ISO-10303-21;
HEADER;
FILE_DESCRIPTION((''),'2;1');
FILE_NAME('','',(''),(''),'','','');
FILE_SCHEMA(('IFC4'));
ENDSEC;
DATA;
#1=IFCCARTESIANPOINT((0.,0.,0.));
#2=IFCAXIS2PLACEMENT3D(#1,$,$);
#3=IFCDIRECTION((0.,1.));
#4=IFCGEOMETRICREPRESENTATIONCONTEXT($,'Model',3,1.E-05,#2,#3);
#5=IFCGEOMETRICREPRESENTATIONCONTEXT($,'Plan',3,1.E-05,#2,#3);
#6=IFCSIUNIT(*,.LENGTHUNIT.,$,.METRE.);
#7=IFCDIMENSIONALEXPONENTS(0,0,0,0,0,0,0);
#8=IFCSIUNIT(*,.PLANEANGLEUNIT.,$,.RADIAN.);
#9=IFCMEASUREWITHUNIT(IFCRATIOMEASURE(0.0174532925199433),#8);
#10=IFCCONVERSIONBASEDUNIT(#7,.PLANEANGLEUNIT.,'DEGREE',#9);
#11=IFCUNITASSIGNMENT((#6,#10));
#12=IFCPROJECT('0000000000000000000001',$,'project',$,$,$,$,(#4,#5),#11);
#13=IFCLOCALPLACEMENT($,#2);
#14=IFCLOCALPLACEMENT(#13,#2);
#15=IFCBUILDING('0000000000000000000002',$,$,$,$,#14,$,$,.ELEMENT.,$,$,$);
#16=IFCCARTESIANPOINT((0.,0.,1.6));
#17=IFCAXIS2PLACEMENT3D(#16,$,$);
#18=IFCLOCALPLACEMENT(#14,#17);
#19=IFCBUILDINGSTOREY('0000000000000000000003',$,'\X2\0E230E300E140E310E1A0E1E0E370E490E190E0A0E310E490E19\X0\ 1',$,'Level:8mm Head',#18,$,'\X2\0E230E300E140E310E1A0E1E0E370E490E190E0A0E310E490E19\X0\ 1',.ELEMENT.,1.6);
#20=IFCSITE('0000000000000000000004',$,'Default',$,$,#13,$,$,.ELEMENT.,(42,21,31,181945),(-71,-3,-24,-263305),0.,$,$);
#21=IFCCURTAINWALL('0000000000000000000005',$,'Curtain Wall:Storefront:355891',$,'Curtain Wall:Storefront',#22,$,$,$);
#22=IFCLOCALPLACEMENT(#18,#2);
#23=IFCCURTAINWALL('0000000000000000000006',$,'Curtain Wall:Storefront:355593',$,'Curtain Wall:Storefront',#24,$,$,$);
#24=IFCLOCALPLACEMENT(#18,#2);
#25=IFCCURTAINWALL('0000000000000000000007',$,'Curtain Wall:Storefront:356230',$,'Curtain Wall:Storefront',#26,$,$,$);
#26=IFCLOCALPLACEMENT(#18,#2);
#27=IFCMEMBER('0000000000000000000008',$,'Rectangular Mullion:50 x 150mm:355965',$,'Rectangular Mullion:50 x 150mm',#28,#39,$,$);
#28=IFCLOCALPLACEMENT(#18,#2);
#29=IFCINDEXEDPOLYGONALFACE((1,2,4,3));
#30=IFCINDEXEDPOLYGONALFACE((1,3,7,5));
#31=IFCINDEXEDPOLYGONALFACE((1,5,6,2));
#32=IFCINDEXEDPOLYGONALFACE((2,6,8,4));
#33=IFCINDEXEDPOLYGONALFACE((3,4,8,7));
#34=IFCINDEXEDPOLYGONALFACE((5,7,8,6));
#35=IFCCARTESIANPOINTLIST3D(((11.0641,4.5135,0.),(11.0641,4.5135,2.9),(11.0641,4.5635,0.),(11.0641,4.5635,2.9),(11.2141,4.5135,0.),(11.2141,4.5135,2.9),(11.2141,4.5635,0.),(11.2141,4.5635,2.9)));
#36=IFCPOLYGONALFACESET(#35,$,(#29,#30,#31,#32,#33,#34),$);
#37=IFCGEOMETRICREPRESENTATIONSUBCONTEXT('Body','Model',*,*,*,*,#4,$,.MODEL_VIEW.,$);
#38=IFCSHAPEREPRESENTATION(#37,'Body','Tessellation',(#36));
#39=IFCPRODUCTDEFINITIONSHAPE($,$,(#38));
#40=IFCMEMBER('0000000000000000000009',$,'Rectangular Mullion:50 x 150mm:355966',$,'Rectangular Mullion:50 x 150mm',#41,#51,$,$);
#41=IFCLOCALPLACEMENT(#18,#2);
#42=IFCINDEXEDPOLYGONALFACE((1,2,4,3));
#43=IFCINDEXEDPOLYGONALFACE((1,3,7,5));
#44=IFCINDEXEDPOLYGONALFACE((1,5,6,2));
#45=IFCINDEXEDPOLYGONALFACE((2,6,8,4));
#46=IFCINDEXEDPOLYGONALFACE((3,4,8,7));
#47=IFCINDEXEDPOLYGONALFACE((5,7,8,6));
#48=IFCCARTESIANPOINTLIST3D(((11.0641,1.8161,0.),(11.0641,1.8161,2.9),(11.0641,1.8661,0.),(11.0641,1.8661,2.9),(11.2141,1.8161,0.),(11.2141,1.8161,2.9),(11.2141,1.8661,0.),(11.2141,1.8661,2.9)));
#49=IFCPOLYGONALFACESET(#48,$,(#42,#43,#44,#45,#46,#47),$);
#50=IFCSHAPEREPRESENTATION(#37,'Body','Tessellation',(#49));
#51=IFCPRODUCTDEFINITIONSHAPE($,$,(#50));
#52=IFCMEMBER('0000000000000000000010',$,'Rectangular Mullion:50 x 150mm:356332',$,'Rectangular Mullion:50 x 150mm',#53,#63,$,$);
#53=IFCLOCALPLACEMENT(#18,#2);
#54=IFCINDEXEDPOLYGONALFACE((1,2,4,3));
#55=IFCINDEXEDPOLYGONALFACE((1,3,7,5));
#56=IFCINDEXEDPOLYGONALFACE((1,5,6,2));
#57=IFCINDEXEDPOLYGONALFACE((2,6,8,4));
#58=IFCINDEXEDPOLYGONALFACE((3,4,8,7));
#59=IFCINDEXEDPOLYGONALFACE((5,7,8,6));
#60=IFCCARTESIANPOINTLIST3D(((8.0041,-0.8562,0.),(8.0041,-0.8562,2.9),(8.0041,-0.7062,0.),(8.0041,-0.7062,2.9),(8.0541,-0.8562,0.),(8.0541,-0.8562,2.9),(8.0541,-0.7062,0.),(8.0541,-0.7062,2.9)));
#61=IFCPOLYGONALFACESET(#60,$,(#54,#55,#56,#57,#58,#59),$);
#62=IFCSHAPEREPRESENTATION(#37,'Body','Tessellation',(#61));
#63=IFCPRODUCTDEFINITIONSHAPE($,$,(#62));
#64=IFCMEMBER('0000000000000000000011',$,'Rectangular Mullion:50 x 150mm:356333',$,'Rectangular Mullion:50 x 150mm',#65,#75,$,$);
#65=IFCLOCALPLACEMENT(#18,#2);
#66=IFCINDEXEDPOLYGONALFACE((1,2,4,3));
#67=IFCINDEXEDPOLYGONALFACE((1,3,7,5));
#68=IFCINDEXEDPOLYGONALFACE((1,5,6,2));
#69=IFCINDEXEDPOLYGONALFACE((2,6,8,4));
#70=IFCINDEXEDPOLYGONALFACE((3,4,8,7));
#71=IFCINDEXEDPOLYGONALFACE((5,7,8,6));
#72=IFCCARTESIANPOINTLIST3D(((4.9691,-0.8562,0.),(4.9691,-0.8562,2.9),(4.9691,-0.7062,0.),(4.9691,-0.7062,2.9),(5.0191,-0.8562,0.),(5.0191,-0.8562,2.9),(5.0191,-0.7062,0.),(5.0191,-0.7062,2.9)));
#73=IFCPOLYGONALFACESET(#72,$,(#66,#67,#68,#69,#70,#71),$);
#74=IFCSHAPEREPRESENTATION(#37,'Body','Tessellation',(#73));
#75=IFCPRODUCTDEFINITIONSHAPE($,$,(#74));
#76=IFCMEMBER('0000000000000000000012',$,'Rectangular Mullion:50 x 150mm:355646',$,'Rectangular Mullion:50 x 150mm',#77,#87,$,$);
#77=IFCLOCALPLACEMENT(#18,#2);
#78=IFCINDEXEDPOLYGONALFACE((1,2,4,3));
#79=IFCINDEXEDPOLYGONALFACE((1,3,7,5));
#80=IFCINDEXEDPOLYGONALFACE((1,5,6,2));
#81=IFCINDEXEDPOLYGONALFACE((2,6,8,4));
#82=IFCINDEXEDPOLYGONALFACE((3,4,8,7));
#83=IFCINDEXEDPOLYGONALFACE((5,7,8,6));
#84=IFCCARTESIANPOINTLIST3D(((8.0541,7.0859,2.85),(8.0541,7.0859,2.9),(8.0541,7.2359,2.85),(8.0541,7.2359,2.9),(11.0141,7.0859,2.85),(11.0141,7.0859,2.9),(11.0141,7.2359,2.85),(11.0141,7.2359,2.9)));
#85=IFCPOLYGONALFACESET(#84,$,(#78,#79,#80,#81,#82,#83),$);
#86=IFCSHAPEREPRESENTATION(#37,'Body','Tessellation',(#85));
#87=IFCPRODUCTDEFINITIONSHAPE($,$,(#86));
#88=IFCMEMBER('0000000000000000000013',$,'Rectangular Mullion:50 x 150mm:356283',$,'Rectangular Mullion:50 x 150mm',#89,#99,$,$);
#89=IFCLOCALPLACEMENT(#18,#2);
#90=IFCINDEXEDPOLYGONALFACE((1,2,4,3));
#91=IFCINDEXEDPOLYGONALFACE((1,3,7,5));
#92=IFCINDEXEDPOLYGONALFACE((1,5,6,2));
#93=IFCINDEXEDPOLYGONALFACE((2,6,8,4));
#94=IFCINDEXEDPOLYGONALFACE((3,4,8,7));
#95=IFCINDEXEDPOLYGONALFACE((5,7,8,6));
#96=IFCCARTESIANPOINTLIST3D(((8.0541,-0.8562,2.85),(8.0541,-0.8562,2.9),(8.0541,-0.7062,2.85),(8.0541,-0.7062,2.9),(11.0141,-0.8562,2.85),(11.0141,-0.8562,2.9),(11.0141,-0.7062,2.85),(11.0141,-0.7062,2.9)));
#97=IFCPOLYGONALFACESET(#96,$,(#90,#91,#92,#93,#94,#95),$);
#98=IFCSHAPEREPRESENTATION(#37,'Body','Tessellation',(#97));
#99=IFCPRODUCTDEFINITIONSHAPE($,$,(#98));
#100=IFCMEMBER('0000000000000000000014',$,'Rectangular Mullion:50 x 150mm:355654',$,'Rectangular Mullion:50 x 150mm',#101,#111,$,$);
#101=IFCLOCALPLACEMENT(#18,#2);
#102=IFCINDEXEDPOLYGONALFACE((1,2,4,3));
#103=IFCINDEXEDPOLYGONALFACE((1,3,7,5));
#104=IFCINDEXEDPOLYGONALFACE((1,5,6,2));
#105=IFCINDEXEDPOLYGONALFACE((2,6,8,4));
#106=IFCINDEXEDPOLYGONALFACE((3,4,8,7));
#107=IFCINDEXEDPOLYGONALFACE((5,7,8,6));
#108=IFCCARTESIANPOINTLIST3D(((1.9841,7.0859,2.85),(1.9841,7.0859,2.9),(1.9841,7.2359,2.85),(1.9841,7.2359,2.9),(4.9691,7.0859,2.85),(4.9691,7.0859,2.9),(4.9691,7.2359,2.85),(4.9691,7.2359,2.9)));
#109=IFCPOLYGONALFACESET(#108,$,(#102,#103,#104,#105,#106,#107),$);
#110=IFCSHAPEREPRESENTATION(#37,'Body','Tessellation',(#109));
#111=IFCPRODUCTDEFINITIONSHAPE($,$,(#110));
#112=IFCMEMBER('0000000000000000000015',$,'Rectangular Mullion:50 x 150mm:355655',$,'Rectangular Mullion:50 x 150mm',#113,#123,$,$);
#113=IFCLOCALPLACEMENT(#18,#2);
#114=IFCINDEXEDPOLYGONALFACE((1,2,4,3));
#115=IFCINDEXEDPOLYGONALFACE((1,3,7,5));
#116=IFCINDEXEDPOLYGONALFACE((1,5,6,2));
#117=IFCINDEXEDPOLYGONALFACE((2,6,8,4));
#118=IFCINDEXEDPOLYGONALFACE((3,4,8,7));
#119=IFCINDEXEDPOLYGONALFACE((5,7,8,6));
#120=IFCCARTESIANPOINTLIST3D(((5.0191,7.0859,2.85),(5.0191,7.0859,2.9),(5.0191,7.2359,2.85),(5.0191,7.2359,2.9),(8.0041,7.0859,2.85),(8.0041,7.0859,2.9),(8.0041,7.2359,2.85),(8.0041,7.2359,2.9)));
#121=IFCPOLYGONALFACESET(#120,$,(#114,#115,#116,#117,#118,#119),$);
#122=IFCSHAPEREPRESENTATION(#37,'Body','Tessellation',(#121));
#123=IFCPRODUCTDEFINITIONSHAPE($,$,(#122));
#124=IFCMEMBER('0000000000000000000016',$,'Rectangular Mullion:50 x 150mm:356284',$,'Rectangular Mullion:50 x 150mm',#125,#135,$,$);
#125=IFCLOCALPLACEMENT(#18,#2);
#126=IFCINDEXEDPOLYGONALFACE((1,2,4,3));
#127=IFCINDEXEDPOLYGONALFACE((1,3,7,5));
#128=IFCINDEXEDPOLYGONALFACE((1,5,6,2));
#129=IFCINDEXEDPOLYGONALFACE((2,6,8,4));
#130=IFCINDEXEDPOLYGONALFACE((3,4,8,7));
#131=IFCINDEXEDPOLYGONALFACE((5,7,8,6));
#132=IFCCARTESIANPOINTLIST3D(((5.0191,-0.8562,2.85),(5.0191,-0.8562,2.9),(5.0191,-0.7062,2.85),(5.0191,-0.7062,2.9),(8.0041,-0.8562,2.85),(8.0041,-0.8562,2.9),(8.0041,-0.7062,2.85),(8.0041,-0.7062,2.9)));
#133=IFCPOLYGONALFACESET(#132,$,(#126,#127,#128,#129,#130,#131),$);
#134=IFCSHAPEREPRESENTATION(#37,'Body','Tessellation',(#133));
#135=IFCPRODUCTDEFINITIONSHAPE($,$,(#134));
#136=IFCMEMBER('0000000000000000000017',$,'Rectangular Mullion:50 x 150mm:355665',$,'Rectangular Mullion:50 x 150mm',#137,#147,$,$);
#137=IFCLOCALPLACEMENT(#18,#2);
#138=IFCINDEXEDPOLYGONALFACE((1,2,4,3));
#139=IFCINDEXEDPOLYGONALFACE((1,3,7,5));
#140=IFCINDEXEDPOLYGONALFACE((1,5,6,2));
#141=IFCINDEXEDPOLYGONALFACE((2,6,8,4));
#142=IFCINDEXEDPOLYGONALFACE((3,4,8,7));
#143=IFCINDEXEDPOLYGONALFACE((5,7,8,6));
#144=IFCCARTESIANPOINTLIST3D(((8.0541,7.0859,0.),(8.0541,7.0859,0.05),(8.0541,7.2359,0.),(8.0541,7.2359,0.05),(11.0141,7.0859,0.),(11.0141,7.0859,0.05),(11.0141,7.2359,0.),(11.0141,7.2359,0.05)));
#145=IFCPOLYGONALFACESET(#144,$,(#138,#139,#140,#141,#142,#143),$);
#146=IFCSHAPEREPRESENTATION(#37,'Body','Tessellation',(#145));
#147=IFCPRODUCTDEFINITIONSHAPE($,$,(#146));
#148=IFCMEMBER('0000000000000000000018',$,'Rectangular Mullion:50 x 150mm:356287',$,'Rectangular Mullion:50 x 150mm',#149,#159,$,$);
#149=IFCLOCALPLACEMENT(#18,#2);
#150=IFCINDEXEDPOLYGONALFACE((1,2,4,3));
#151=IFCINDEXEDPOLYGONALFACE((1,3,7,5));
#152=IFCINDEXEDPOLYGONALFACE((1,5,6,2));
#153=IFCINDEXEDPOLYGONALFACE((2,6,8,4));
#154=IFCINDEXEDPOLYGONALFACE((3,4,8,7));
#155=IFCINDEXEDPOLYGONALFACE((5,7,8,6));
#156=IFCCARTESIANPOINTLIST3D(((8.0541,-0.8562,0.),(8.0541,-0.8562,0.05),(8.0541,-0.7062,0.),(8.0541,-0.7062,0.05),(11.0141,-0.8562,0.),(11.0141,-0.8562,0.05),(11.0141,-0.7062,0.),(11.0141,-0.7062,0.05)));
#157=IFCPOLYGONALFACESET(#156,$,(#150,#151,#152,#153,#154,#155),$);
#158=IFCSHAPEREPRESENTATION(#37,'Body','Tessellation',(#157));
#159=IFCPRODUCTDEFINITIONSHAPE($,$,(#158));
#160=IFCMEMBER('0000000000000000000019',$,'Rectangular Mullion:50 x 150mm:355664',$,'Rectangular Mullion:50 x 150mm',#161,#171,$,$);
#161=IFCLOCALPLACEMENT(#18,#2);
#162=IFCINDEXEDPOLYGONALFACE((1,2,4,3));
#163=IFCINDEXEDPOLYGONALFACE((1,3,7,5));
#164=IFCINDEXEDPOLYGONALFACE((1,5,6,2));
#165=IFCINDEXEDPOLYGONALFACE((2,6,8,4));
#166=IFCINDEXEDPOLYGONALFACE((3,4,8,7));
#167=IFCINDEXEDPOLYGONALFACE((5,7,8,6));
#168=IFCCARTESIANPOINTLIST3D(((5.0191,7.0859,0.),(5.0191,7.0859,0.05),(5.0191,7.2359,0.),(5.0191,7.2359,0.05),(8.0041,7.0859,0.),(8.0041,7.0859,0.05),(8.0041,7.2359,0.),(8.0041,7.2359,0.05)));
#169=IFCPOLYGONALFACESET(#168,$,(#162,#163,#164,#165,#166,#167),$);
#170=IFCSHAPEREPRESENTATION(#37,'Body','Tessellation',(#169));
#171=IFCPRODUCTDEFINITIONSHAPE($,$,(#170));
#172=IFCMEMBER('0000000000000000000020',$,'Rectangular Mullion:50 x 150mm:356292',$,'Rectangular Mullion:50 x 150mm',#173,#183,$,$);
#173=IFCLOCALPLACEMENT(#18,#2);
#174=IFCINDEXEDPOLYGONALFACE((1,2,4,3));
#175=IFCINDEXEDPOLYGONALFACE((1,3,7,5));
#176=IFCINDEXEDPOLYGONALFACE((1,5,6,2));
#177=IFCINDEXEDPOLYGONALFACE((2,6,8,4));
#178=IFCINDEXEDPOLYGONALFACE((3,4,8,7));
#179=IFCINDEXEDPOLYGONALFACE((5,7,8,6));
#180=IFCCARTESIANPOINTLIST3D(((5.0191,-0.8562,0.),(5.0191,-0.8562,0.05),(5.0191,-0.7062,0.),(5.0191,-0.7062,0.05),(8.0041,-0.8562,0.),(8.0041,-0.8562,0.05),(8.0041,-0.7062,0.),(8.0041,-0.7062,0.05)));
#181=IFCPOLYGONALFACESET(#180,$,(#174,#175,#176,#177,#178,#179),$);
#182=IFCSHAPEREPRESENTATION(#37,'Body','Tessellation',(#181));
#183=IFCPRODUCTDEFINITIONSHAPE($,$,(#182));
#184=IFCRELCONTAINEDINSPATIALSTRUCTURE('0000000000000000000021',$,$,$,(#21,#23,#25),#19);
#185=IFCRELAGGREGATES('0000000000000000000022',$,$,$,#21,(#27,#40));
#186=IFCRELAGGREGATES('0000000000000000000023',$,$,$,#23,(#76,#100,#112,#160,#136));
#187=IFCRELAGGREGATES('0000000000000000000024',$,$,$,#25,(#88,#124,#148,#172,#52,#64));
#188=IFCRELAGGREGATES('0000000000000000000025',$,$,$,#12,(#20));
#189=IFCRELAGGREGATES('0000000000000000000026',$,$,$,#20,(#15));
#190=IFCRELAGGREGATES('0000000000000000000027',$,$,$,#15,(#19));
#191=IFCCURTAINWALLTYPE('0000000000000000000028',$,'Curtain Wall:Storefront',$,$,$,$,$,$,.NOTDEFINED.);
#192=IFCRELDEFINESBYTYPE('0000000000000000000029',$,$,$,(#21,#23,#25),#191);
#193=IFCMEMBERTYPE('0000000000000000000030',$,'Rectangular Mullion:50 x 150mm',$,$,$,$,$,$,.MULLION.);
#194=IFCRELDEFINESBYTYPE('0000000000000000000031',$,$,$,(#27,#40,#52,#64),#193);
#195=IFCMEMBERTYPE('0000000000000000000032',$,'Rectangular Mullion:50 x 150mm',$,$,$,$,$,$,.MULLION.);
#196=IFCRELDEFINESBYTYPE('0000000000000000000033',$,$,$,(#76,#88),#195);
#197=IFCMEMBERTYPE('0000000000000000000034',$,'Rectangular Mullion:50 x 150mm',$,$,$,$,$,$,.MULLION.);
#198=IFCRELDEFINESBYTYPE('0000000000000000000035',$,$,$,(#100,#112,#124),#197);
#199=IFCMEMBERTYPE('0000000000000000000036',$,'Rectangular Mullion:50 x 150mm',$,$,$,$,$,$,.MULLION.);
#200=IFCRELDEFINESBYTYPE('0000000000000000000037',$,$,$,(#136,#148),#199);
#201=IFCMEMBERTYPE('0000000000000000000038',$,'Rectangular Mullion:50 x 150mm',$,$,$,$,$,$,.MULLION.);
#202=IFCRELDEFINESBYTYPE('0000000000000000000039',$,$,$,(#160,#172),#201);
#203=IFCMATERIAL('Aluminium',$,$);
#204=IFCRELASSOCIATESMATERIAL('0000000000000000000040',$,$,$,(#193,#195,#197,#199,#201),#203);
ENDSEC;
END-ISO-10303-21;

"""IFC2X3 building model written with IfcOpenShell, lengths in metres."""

from ifc_helpers import new_model, entity, si_unit, converted_unit, direction, frame, origin, origin_2d_with_axis, place, context, subcontext, project, spatial, rectangle, extrude, source, transform, mapped, material, type_object, type_shapes, element, aggregate, save


model = new_model("IFC2X3")

# Units and contexts
model_context = context("Model", 3, precision=1e-05, world=origin(), true_north=direction((0.0, 1.0)))
plan_context = context("Plan", 3, precision=1e-05, world=origin(), true_north=direction((0.0, 1.0)))
body_context = subcontext(model_context, "Body", "Model", "MODEL_VIEW")
ifc_project = project(units=[si_unit("LENGTHUNIT", "METRE"), converted_unit("PLANEANGLEUNIT", "DEGREE", entity("IfcRatioMeasure", 0.0174532925199433), si_unit("PLANEANGLEUNIT", "RADIAN"), dimensions=[0, 0, 0, 0, 0, 0, 0])], contexts=[model_context, plan_context])

# Site, building, storey
site_placement = place(None, origin())
site = spatial("IfcSite", under=ifc_project, at=site_placement, Name="Default", CompositionType="ELEMENT", RefLatitude=(42, 21, 31, 181945), RefLongitude=(-71, -3, -24, -263305), RefElevation=0.0)
building_placement = place(site_placement, origin())
building = spatial("IfcBuilding", under=site, at=building_placement, CompositionType="ELEMENT")
storey_placement = place(building_placement, frame((0.0, 0.0, 1.6)))
storey = spatial("IfcBuildingStorey", under=building, at=storey_placement, Name="ระดับพื้นชั้น 1", ObjectType="Level:8mm Head", LongName="ระดับพื้นชั้น 1", CompositionType="ELEMENT", Elevation=1.6)

# Curtain wall
curtain_wall_type = type_object("IfcCurtainWallType", Name="Curtain Wall:Storefront", PredefinedType="NOTDEFINED")
curtain_wall_1_placement = place(storey_placement, frame((0.0, 0.0, -1.6)))
curtain_wall_1 = element("IfcCurtainWall", 1, at=curtain_wall_1_placement, inside=storey, type_object=curtain_wall_type, Name="Curtain Wall:Storefront:355891", ObjectType="Curtain Wall:Storefront")
ifc_material_1 = material(Name="Aluminium")

# Curtain wall
curtain_wall_2_placement = place(storey_placement, frame((0.0, 0.0, -1.6)))
curtain_wall_2 = element("IfcCurtainWall", 2, at=curtain_wall_2_placement, inside=storey, type_object=curtain_wall_type, Name="Curtain Wall:Storefront:355593", ObjectType="Curtain Wall:Storefront")

# Curtain wall
curtain_wall_3_placement = place(storey_placement, frame((0.0, 0.0, -1.6)))
curtain_wall_3 = element("IfcCurtainWall", 3, at=curtain_wall_3_placement, inside=storey, type_object=curtain_wall_type, Name="Curtain Wall:Storefront:356230", ObjectType="Curtain Wall:Storefront")

# Members
member_type_1 = type_object("IfcMemberType", Name="Rectangular Mullion:50 x 150mm", PredefinedType="MULLION", material=ifc_material_1)
shared_shape_1 = source(origin(), body_context, "Body", "SweptSolid", [
    extrude(rectangle(XDim=0.15, YDim=0.05, at=origin_2d_with_axis()), frame((0.0, 0.0, -2.9), z_axis=(0.0, 0.0, 1.0), x_axis=(0.0, -1.0, 0.0)), (0.0, 0.0, 1.0), 2.9),
])
type_shapes(member_type_1, [shared_shape_1])
member_1_placement = place(curtain_wall_1_placement, frame((11.1391, 4.5385, 1.6), z_axis=(0.0, 0.0, -1.0), x_axis=(0.0, -1.0, 0.0)))
member_1 = element("IfcMember", 4, at=member_1_placement, type_object=member_type_1, Name="Rectangular Mullion:50 x 150mm:355965", ObjectType="Rectangular Mullion:50 x 150mm", context=body_context, shape_type="MappedRepresentation", body=[
    mapped(shared_shape_1, transform((0.0, 0.0, 0.0), scale=1.0)),
])
member_2_placement = place(curtain_wall_1_placement, frame((11.1391, 1.8411, 1.6), z_axis=(0.0, 0.0, -1.0), x_axis=(0.0, -1.0, 0.0)))
member_2 = element("IfcMember", 5, at=member_2_placement, type_object=member_type_1, Name="Rectangular Mullion:50 x 150mm:355966", ObjectType="Rectangular Mullion:50 x 150mm", context=body_context, shape_type="MappedRepresentation", body=[
    mapped(shared_shape_1, transform((0.0, 0.0, 0.0), scale=1.0)),
])
member_3_placement = place(curtain_wall_3_placement, frame((8.0291, -0.7812, 1.6), z_axis=(0.0, 0.0, -1.0), x_axis=(-1.0, 0.0, 0.0)))
member_3 = element("IfcMember", 6, at=member_3_placement, type_object=member_type_1, Name="Rectangular Mullion:50 x 150mm:356332", ObjectType="Rectangular Mullion:50 x 150mm", context=body_context, shape_type="MappedRepresentation", body=[
    mapped(shared_shape_1, transform((0.0, 0.0, 0.0), scale=1.0)),
])
member_4_placement = place(curtain_wall_3_placement, frame((4.9941, -0.7812, 1.6), z_axis=(0.0, 0.0, -1.0), x_axis=(-1.0, 0.0, 0.0)))
member_4 = element("IfcMember", 7, at=member_4_placement, type_object=member_type_1, Name="Rectangular Mullion:50 x 150mm:356333", ObjectType="Rectangular Mullion:50 x 150mm", context=body_context, shape_type="MappedRepresentation", body=[
    mapped(shared_shape_1, transform((0.0, 0.0, 0.0), scale=1.0)),
])
member_type_2 = type_object("IfcMemberType", Name="Rectangular Mullion:50 x 150mm", PredefinedType="MULLION", material=ifc_material_1)
shared_shape_2 = source(origin(), body_context, "Body", "SweptSolid", [
    extrude(rectangle(XDim=0.15, YDim=0.05, at=origin_2d_with_axis()), frame((-0.025, 0.0, -2.96), z_axis=(0.0, 0.0, 1.0), x_axis=(0.0, -1.0, 0.0)), (0.0, 0.0, 1.0), 2.96),
])
type_shapes(member_type_2, [shared_shape_2])
member_5_placement = place(curtain_wall_2_placement, frame((11.0141, 7.1609, 4.5), z_axis=(1.0, 0.0, 0.0), x_axis=(0.0, 0.0, 1.0)))
member_5 = element("IfcMember", 8, at=member_5_placement, type_object=member_type_2, Name="Rectangular Mullion:50 x 150mm:355646", ObjectType="Rectangular Mullion:50 x 150mm", context=body_context, shape_type="MappedRepresentation", body=[
    mapped(shared_shape_2, transform((0.0, 0.0, 0.0), scale=1.0)),
])
member_6_placement = place(curtain_wall_3_placement, frame((8.0541, -0.7812, 4.5), z_axis=(-1.0, 0.0, 0.0), x_axis=(0.0, 0.0, 1.0)))
member_6 = element("IfcMember", 9, at=member_6_placement, type_object=member_type_2, Name="Rectangular Mullion:50 x 150mm:356283", ObjectType="Rectangular Mullion:50 x 150mm", context=body_context, shape_type="MappedRepresentation", body=[
    mapped(shared_shape_2, transform((0.0, 0.0, 0.0), scale=1.0)),
])
member_type_3 = type_object("IfcMemberType", Name="Rectangular Mullion:50 x 150mm", PredefinedType="MULLION", material=ifc_material_1)
shared_shape_3 = source(origin(), body_context, "Body", "SweptSolid", [
    extrude(rectangle(XDim=0.15, YDim=0.05, at=origin_2d_with_axis()), frame((-0.025, 0.0, -2.985), z_axis=(0.0, 0.0, 1.0), x_axis=(0.0, -1.0, 0.0)), (0.0, 0.0, 1.0), 2.985),
])
type_shapes(member_type_3, [shared_shape_3])
member_7_placement = place(curtain_wall_2_placement, frame((4.9691, 7.1609, 4.5), z_axis=(1.0, 0.0, 0.0), x_axis=(0.0, 0.0, 1.0)))
member_7 = element("IfcMember", 10, at=member_7_placement, type_object=member_type_3, Name="Rectangular Mullion:50 x 150mm:355654", ObjectType="Rectangular Mullion:50 x 150mm", context=body_context, shape_type="MappedRepresentation", body=[
    mapped(shared_shape_3, transform((0.0, 0.0, 0.0), scale=1.0)),
])
member_8_placement = place(curtain_wall_2_placement, frame((8.0041, 7.1609, 4.5), z_axis=(1.0, 0.0, 0.0), x_axis=(0.0, 0.0, 1.0)))
member_8 = element("IfcMember", 11, at=member_8_placement, type_object=member_type_3, Name="Rectangular Mullion:50 x 150mm:355655", ObjectType="Rectangular Mullion:50 x 150mm", context=body_context, shape_type="MappedRepresentation", body=[
    mapped(shared_shape_3, transform((0.0, 0.0, 0.0), scale=1.0)),
])
member_9_placement = place(curtain_wall_3_placement, frame((5.0191, -0.7812, 4.5), z_axis=(-1.0, 0.0, 0.0), x_axis=(0.0, 0.0, 1.0)))
member_9 = element("IfcMember", 12, at=member_9_placement, type_object=member_type_3, Name="Rectangular Mullion:50 x 150mm:356284", ObjectType="Rectangular Mullion:50 x 150mm", context=body_context, shape_type="MappedRepresentation", body=[
    mapped(shared_shape_3, transform((0.0, 0.0, 0.0), scale=1.0)),
])
member_type_4 = type_object("IfcMemberType", Name="Rectangular Mullion:50 x 150mm", PredefinedType="MULLION", material=ifc_material_1)
shared_shape_4 = source(origin(), body_context, "Body", "SweptSolid", [
    extrude(rectangle(XDim=0.15, YDim=0.05, at=origin_2d_with_axis()), frame((-0.025, 0.0, -2.96), z_axis=(0.0, 0.0, 1.0), x_axis=(0.0, -1.0, 0.0)), (0.0, 0.0, 1.0), 2.96),
])
type_shapes(member_type_4, [shared_shape_4])
member_10_placement = place(curtain_wall_2_placement, frame((8.0541, 7.1609, 1.6), z_axis=(-1.0, 0.0, 0.0), x_axis=(0.0, 0.0, -1.0)))
member_10 = element("IfcMember", 13, at=member_10_placement, type_object=member_type_4, Name="Rectangular Mullion:50 x 150mm:355665", ObjectType="Rectangular Mullion:50 x 150mm", context=body_context, shape_type="MappedRepresentation", body=[
    mapped(shared_shape_4, transform((0.0, 0.0, 0.0), scale=1.0)),
])
member_11_placement = place(curtain_wall_3_placement, frame((11.0141, -0.7812, 1.6), z_axis=(1.0, 0.0, 0.0), x_axis=(0.0, 0.0, -1.0)))
member_11 = element("IfcMember", 14, at=member_11_placement, type_object=member_type_4, Name="Rectangular Mullion:50 x 150mm:356287", ObjectType="Rectangular Mullion:50 x 150mm", context=body_context, shape_type="MappedRepresentation", body=[
    mapped(shared_shape_4, transform((0.0, 0.0, 0.0), scale=1.0)),
])
member_type_5 = type_object("IfcMemberType", Name="Rectangular Mullion:50 x 150mm", PredefinedType="MULLION", material=ifc_material_1)
shared_shape_5 = source(origin(), body_context, "Body", "SweptSolid", [
    extrude(rectangle(XDim=0.15, YDim=0.05, at=origin_2d_with_axis()), frame((-0.025, 0.0, -2.985), z_axis=(0.0, 0.0, 1.0), x_axis=(0.0, -1.0, 0.0)), (0.0, 0.0, 1.0), 2.985),
])
type_shapes(member_type_5, [shared_shape_5])
member_12_placement = place(curtain_wall_2_placement, frame((5.0191, 7.1609, 1.6), z_axis=(-1.0, 0.0, 0.0), x_axis=(0.0, 0.0, -1.0)))
member_12 = element("IfcMember", 15, at=member_12_placement, type_object=member_type_5, Name="Rectangular Mullion:50 x 150mm:355664", ObjectType="Rectangular Mullion:50 x 150mm", context=body_context, shape_type="MappedRepresentation", body=[
    mapped(shared_shape_5, transform((0.0, 0.0, 0.0), scale=1.0)),
])
member_13_placement = place(curtain_wall_3_placement, frame((8.0041, -0.7812, 1.6), z_axis=(1.0, 0.0, 0.0), x_axis=(0.0, 0.0, -1.0)))
member_13 = element("IfcMember", 16, at=member_13_placement, type_object=member_type_5, Name="Rectangular Mullion:50 x 150mm:356292", ObjectType="Rectangular Mullion:50 x 150mm", context=body_context, shape_type="MappedRepresentation", body=[
    mapped(shared_shape_5, transform((0.0, 0.0, 0.0), scale=1.0)),
])

aggregate(curtain_wall_1, [member_1, member_2])
aggregate(curtain_wall_2, [member_5, member_7, member_8, member_12, member_10])
aggregate(curtain_wall_3, [member_6, member_9, member_11, member_13, member_3, member_4])

save(model, "model.ifc")
